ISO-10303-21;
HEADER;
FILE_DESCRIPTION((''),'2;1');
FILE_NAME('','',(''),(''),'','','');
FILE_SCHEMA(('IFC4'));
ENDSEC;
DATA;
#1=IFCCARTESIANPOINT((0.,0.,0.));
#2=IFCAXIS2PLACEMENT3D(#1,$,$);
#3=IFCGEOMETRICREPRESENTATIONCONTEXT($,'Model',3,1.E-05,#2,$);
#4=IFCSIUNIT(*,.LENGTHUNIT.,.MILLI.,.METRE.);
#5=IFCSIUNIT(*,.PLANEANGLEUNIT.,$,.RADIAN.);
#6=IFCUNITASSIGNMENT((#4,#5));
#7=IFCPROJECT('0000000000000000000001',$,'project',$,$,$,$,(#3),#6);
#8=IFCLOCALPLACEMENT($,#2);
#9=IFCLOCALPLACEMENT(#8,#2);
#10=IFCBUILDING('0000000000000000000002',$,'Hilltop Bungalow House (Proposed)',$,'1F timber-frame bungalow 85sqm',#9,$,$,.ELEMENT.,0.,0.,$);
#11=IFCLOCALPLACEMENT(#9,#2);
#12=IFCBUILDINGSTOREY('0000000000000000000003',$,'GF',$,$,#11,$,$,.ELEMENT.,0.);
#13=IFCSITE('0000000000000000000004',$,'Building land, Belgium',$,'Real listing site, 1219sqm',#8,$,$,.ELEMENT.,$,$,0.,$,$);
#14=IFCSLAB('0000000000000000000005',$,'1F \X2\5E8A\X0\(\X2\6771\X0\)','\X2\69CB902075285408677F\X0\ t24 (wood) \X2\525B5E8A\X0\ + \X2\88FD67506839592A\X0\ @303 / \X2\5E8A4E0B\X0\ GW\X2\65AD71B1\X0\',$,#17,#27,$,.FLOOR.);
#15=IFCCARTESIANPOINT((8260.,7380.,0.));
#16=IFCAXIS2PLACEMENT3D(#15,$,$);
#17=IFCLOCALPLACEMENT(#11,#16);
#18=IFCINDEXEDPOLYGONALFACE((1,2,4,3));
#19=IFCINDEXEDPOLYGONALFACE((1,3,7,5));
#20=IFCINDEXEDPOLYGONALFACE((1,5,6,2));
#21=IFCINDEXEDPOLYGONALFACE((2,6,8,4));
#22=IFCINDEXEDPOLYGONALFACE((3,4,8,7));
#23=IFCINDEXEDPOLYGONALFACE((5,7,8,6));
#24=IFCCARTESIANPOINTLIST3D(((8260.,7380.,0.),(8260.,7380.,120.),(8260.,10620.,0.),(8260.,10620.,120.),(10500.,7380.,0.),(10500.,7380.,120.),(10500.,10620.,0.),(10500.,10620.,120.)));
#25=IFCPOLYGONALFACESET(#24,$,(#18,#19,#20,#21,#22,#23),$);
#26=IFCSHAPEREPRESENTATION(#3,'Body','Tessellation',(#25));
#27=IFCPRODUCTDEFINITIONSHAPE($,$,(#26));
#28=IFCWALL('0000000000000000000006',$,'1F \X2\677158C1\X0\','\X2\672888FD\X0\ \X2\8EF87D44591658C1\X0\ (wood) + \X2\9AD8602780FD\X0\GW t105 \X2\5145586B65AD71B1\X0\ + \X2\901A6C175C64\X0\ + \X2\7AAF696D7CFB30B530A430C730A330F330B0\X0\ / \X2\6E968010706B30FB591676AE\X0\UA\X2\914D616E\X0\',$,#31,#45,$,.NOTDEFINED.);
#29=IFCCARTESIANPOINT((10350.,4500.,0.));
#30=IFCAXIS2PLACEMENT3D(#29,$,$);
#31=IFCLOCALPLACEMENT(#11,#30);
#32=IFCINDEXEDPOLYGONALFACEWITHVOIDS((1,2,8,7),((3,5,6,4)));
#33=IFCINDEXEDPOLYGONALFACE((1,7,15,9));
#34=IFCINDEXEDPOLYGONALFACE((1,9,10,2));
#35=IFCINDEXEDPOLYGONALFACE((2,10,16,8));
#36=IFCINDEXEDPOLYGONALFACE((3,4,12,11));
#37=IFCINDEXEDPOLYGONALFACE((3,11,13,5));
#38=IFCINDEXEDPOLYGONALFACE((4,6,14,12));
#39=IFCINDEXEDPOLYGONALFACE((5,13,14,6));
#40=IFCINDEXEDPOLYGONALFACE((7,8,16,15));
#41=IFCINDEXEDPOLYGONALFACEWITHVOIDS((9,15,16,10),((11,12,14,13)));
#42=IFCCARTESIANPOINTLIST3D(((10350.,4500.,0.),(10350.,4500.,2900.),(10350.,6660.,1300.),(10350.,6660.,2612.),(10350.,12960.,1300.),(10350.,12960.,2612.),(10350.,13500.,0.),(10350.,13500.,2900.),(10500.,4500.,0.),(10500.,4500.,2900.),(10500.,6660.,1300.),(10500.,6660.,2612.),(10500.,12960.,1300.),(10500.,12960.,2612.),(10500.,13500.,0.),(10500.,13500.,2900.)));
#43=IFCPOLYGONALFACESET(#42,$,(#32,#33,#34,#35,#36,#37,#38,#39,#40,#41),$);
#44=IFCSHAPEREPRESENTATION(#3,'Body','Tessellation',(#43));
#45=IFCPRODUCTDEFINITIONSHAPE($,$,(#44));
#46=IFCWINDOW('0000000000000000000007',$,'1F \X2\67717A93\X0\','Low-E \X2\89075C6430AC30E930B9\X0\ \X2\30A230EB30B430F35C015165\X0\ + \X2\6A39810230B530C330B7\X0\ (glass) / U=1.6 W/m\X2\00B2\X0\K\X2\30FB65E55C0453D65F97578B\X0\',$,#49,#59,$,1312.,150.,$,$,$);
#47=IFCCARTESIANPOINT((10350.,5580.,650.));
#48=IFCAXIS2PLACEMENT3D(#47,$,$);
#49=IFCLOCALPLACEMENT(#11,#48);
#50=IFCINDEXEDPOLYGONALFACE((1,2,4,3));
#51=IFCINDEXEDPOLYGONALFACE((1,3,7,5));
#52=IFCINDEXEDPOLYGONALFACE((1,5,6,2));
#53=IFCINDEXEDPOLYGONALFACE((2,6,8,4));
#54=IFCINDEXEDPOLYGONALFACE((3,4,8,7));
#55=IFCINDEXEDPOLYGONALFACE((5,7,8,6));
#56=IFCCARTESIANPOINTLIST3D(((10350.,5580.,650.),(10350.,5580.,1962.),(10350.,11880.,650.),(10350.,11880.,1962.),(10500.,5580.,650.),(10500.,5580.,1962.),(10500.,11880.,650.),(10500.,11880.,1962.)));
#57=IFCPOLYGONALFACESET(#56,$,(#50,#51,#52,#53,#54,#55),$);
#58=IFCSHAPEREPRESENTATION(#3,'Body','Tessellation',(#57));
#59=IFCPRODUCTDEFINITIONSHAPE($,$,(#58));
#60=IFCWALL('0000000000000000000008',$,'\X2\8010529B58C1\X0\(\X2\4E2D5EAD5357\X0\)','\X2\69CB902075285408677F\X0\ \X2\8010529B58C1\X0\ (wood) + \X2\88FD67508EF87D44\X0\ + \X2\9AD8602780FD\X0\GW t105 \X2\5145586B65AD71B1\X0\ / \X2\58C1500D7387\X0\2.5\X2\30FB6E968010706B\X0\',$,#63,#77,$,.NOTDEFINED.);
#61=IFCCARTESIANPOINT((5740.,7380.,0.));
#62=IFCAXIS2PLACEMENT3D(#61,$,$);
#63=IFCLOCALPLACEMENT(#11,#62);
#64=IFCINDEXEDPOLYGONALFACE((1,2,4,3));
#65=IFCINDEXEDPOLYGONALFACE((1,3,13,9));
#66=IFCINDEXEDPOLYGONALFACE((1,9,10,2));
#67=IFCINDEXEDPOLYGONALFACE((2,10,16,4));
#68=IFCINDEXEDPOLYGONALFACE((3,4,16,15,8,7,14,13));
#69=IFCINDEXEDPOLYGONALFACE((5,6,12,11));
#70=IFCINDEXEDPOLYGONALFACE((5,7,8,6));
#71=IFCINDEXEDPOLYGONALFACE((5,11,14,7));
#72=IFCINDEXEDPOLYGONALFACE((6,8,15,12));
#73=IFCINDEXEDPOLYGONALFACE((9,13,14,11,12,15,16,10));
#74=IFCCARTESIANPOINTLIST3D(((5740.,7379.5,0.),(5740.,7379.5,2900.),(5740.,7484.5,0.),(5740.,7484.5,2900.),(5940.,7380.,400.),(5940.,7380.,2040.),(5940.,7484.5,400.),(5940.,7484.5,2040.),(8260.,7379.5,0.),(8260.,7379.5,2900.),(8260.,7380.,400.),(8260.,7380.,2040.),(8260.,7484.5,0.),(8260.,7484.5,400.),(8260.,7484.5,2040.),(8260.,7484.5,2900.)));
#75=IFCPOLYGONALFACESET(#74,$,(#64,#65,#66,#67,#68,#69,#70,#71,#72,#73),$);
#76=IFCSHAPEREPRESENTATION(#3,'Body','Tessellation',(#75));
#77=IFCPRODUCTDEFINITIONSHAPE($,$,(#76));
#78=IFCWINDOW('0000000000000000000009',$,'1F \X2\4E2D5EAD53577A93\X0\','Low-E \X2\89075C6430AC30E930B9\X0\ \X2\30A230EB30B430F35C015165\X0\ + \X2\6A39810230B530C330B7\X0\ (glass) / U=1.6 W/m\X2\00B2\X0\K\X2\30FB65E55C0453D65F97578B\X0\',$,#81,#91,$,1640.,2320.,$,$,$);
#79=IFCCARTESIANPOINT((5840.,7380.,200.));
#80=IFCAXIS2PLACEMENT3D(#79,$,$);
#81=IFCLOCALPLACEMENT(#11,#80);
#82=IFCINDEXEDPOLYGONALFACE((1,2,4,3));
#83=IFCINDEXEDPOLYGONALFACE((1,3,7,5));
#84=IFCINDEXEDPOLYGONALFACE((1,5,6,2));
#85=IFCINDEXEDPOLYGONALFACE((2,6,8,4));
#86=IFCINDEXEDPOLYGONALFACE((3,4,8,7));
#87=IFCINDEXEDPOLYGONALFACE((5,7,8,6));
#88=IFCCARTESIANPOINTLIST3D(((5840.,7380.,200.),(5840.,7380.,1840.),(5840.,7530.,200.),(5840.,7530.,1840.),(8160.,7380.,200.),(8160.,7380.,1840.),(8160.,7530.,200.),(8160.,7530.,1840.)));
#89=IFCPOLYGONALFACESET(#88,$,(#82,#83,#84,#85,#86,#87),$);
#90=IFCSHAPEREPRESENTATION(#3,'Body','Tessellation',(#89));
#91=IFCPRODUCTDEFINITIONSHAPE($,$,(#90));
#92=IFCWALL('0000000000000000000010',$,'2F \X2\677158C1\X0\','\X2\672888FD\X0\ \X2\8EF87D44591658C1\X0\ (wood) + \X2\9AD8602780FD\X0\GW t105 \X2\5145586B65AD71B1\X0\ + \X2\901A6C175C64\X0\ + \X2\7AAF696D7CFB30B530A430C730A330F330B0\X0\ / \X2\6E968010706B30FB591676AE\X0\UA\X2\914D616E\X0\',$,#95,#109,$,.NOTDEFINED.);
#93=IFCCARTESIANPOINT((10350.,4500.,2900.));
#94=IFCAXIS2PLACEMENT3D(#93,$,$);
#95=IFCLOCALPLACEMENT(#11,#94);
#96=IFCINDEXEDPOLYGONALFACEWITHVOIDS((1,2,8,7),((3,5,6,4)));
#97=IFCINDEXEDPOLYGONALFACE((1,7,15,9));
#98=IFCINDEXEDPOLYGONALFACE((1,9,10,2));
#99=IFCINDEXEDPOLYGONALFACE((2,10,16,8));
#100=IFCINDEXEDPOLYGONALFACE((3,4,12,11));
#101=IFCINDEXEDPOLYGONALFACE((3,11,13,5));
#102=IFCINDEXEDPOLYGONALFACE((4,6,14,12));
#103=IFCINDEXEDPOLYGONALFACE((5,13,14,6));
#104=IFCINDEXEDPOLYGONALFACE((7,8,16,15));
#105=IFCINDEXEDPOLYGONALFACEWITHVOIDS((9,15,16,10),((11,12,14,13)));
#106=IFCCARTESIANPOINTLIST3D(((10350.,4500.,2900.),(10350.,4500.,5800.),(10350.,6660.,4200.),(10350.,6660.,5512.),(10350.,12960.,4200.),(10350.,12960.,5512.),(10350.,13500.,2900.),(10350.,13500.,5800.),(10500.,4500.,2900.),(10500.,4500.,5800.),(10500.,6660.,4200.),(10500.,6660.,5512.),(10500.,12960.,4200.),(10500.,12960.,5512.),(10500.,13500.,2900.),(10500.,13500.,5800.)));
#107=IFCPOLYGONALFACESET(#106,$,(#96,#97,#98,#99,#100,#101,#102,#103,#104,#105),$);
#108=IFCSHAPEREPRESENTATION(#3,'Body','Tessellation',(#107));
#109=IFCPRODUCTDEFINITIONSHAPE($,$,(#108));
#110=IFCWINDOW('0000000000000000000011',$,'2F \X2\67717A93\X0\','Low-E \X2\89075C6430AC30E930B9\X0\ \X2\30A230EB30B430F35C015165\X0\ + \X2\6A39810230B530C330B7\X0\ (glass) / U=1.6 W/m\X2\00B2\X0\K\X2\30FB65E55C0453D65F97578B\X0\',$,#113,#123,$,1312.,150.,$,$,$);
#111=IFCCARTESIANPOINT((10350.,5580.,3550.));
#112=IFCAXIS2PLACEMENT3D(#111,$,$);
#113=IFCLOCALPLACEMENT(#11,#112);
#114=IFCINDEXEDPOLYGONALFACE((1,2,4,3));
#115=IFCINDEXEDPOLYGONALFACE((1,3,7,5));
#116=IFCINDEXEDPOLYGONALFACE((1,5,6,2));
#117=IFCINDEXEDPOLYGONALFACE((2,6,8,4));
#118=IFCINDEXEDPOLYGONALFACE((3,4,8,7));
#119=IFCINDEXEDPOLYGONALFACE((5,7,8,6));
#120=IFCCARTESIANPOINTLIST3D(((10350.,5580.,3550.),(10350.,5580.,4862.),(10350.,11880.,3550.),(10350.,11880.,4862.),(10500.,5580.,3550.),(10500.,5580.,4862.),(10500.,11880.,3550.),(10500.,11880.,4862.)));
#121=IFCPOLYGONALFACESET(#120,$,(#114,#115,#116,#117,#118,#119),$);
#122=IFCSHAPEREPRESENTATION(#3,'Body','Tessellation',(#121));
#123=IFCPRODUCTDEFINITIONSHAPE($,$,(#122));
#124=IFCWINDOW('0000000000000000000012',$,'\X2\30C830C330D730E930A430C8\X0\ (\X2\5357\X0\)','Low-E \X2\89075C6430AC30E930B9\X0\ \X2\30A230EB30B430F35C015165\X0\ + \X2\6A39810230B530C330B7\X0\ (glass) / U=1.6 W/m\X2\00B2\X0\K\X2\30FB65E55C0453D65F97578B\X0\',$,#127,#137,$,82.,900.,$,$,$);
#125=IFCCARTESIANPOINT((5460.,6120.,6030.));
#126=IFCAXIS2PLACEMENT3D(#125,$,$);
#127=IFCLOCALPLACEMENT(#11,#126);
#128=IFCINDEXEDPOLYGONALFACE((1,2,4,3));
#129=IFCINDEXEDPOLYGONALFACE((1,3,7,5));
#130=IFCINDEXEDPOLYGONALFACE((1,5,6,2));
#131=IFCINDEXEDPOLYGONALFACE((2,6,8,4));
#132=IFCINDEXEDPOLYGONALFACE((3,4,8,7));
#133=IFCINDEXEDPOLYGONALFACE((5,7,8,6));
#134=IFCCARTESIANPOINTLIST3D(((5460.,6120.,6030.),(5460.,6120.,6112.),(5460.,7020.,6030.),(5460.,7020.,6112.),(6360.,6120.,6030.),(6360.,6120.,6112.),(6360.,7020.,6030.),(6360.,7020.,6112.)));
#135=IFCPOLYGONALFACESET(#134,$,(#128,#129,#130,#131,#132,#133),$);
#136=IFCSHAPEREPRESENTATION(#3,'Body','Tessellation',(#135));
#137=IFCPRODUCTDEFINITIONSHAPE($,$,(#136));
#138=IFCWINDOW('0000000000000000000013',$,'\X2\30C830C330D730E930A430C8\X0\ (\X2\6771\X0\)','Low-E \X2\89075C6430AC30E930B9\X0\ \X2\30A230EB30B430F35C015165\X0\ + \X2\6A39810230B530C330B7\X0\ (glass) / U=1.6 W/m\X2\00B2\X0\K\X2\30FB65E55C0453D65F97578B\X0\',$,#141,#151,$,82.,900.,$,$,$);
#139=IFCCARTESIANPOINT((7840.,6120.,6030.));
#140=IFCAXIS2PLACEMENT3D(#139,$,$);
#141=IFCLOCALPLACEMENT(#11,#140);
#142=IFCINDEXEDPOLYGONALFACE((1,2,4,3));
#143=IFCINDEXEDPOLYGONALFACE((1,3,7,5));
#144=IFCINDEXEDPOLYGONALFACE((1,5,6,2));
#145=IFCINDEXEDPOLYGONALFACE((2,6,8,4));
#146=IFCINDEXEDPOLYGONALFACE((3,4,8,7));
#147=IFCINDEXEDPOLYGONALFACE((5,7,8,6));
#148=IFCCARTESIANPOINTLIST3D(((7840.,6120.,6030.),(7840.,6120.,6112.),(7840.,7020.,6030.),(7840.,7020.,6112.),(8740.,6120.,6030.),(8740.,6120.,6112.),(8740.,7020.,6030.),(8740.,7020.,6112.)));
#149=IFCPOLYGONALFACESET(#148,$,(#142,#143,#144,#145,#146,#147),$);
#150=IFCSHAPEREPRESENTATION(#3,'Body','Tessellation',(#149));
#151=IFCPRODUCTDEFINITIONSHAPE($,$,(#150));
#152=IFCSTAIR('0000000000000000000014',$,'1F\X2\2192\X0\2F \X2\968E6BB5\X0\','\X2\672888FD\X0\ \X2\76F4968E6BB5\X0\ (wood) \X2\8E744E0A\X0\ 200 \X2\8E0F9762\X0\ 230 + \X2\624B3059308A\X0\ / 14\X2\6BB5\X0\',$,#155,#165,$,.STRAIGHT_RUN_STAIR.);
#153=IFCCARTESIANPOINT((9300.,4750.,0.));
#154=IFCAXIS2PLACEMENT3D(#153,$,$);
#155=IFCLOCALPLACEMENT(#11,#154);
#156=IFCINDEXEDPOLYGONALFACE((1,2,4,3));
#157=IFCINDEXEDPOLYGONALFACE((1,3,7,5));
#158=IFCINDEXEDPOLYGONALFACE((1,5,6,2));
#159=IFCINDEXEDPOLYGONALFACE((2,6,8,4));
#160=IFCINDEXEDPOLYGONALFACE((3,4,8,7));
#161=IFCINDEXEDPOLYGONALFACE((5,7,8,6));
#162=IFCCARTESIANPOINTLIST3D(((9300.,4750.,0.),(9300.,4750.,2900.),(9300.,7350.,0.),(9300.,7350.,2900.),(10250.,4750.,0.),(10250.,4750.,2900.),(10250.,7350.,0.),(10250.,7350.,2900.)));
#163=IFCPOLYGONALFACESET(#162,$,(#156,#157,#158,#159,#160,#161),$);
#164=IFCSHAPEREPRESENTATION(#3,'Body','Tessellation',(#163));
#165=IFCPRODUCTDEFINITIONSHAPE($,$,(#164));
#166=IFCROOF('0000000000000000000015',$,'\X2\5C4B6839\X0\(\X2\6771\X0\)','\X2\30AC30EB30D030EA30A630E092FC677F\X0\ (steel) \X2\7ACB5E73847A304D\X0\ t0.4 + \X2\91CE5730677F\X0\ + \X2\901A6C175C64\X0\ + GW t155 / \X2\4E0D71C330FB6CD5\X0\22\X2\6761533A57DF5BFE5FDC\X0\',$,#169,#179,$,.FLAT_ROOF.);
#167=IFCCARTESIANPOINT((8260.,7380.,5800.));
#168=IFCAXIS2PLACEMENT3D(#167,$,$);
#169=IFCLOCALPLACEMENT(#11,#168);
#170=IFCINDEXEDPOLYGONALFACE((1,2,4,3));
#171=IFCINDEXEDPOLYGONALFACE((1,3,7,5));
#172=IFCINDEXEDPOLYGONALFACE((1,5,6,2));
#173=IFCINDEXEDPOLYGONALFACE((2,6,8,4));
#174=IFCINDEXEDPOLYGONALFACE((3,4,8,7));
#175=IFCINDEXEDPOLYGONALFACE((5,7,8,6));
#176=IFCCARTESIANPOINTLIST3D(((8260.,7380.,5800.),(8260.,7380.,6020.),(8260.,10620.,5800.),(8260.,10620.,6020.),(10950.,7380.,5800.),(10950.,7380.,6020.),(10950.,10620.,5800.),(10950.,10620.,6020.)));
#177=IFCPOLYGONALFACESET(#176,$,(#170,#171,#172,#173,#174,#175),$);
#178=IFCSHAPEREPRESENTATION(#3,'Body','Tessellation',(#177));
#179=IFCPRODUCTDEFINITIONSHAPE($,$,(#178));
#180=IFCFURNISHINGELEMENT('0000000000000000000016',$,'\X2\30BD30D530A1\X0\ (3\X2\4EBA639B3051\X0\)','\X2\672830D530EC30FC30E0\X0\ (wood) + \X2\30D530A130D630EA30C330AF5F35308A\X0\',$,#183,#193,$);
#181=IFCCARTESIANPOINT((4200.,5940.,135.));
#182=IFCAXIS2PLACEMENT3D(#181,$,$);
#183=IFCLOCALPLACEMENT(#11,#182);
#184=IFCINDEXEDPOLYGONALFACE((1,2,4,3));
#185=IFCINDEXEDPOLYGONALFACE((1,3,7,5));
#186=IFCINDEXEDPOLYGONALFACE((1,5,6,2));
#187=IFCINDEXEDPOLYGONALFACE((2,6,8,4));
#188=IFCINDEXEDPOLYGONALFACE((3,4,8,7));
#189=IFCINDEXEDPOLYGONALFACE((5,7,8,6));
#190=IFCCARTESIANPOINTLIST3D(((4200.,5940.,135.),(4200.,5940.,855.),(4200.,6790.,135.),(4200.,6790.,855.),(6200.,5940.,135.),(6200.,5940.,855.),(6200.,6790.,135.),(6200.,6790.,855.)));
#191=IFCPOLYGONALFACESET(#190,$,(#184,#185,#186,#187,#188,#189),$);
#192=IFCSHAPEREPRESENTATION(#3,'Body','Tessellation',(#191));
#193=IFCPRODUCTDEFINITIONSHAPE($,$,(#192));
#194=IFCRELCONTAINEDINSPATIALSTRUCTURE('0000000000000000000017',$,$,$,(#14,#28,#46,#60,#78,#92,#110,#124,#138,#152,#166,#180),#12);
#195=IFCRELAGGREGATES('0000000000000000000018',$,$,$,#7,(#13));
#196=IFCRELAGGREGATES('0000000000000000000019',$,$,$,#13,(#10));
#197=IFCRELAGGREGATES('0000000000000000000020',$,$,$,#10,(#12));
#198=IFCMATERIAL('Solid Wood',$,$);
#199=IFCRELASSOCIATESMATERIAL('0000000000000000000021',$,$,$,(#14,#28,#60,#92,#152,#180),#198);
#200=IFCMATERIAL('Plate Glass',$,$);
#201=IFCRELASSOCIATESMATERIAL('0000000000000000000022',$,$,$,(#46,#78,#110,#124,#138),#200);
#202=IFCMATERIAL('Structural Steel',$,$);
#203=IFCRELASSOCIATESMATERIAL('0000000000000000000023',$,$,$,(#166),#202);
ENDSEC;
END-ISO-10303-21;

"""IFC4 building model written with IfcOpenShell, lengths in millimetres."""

from ifc_helpers import new_model, si_unit, frame, frame_2d, origin, place, context, project, spatial, rectangle, extrude, material, element, fill, save


model = new_model("IFC4")

# Units and contexts
model_context = context("Model", 3, precision=1e-05, world=origin())
ifc_project = project(units=[si_unit("LENGTHUNIT", "METRE", prefix="MILLI"), si_unit("PLANEANGLEUNIT", "RADIAN")], contexts=[model_context])

# Site, building, storey
site_placement = place(None, origin())
site = spatial("IfcSite", under=ifc_project, at=site_placement, Name="Building land, Belgium", ObjectType="Real listing site, 1219sqm", CompositionType="ELEMENT", RefElevation=0.0)
building_placement = place(site_placement, origin())
building = spatial("IfcBuilding", under=site, at=building_placement, Name="Hilltop Bungalow House (Proposed)", ObjectType="1F timber-frame bungalow 85sqm", CompositionType="ELEMENT", ElevationOfRefHeight=0.0, ElevationOfTerrain=0.0)
storey_placement = place(building_placement, origin())
storey = spatial("IfcBuildingStorey", under=building, at=storey_placement, Name="GF", CompositionType="ELEMENT", Elevation=0.0)

# Slab
ifc_material_1 = material(Name="Solid Wood")
slab_placement = place(storey_placement, frame((8260.0, 7380.0, 0.0)))
element("IfcSlab", 1, at=slab_placement, inside=storey, material=ifc_material_1, Name="1F 床(東)", Description="構造用合板 t24 (wood) 剛床 + 製材根太 @303 / 床下 GW断熱", PredefinedType="FLOOR", context=model_context, shape_type="SweptSolid", body=[
    extrude(rectangle(XDim=2240.0, YDim=3240.0, at=frame_2d((1120.0, 1620.0))), frame((8260.0, 7380.0, 0.0)), (0.0, 0.0, 1.0), 120.0),
])

# Walls, openings, windows
wall_1_placement = place(storey_placement, frame((10350.0, 4500.0, 0.0)))
wall_1 = element("IfcWall", 2, at=wall_1_placement, inside=storey, material=ifc_material_1, Name="1F 東壁", Description="木製 軸組外壁 (wood) + 高性能GW t105 充填断熱 + 通気層 + 窯業系サイディング / 準耐火・外皮UA配慮", PredefinedType="NOTDEFINED", context=model_context, shape_type="SweptSolid", body=[
    extrude(rectangle(XDim=150.0, YDim=9000.0, at=frame_2d((75.0, 4500.0))), frame((10350.0, 4500.0, 0.0)), (0.0, 0.0, 1.0), 2900.0),
])
opening_1_placement = place(storey_placement, frame((10350.0, 5580.0, 650.0)))
opening_1 = element("IfcOpeningElement", 3, at=opening_1_placement, cuts=wall_1, PredefinedType="NOTDEFINED", context=model_context, shape_type="SweptSolid", body=[
    extrude(rectangle(XDim=150.0, YDim=6300.0, at=frame_2d((75.0, 3150.0))), frame((10350.0, 5580.0, 650.0)), (0.0, 0.0, 1.0), 1312.0),
])
ifc_material_2 = material(Name="Plate Glass")
window_1_placement = place(storey_placement, frame((10350.0, 5580.0, 650.0)))
window_1 = element("IfcWindow", 4, at=window_1_placement, inside=storey, material=ifc_material_2, Name="1F 東窓", Description="Low-E 複層ガラス アルゴン封入 + 樹脂サッシ (glass) / U=1.6 W/m²K・日射取得型", OverallHeight=1312.0, OverallWidth=150.0, context=model_context, shape_type="SweptSolid", body=[
    extrude(rectangle(XDim=150.0, YDim=6300.0, at=frame_2d((75.0, 3150.0))), frame((10350.0, 5580.0, 650.0)), (0.0, 0.0, 1.0), 1312.0),
])
fill(opening_1, window_1)
wall_2_placement = place(storey_placement, frame((5740.0, 7380.0, 0.0)))
wall_2 = element("IfcWall", 5, at=wall_2_placement, inside=storey, material=ifc_material_1, Name="耐力壁(中庭南)", Description="構造用合板 耐力壁 (wood) + 製材軸組 + 高性能GW t105 充填断熱 / 壁倍率2.5・準耐火", PredefinedType="NOTDEFINED", context=model_context, shape_type="SweptSolid", body=[
    extrude(rectangle(XDim=2520.0, YDim=105.0, at=frame_2d((1260.0, 52.0))), frame((5740.0, 7380.0, 0.0)), (0.0, 0.0, 1.0), 2900.0),
])
opening_2_placement = place(storey_placement, frame((5840.0, 7380.0, 200.0)))
opening_2 = element("IfcOpeningElement", 6, at=opening_2_placement, cuts=wall_2, PredefinedType="NOTDEFINED", context=model_context, shape_type="SweptSolid", body=[
    extrude(rectangle(XDim=2320.0, YDim=150.0, at=frame_2d((1160.0, 75.0))), frame((5840.0, 7380.0, 200.0)), (0.0, 0.0, 1.0), 1640.0),
])
window_2_placement = place(storey_placement, frame((5840.0, 7380.0, 200.0)))
window_2 = element("IfcWindow", 7, at=window_2_placement, inside=storey, material=ifc_material_2, Name="1F 中庭南窓", Description="Low-E 複層ガラス アルゴン封入 + 樹脂サッシ (glass) / U=1.6 W/m²K・日射取得型", OverallHeight=1640.0, OverallWidth=2320.0, context=model_context, shape_type="SweptSolid", body=[
    extrude(rectangle(XDim=2320.0, YDim=150.0, at=frame_2d((1160.0, 75.0))), frame((5840.0, 7380.0, 200.0)), (0.0, 0.0, 1.0), 1640.0),
])
fill(opening_2, window_2)

# Wall, opening, window
wall_3_placement = place(storey_placement, frame((10350.0, 4500.0, 2900.0)))
wall_3 = element("IfcWall", 8, at=wall_3_placement, inside=storey, material=ifc_material_1, Name="2F 東壁", Description="木製 軸組外壁 (wood) + 高性能GW t105 充填断熱 + 通気層 + 窯業系サイディング / 準耐火・外皮UA配慮", PredefinedType="NOTDEFINED", context=model_context, shape_type="SweptSolid", body=[
    extrude(rectangle(XDim=150.0, YDim=9000.0, at=frame_2d((75.0, 4500.0))), frame((10350.0, 4500.0, 2900.0)), (0.0, 0.0, 1.0), 2900.0),
])
opening_3_placement = place(storey_placement, frame((10350.0, 5580.0, 3550.0)))
opening_3 = element("IfcOpeningElement", 9, at=opening_3_placement, cuts=wall_3, PredefinedType="NOTDEFINED", context=model_context, shape_type="SweptSolid", body=[
    extrude(rectangle(XDim=150.0, YDim=6300.0, at=frame_2d((75.0, 3150.0))), frame((10350.0, 5580.0, 3550.0)), (0.0, 0.0, 1.0), 1312.0),
])
window_3_placement = place(storey_placement, frame((10350.0, 5580.0, 3550.0)))
window_3 = element("IfcWindow", 10, at=window_3_placement, inside=storey, material=ifc_material_2, Name="2F 東窓", Description="Low-E 複層ガラス アルゴン封入 + 樹脂サッシ (glass) / U=1.6 W/m²K・日射取得型", OverallHeight=1312.0, OverallWidth=150.0, context=model_context, shape_type="SweptSolid", body=[
    extrude(rectangle(XDim=150.0, YDim=6300.0, at=frame_2d((75.0, 3150.0))), frame((10350.0, 5580.0, 3550.0)), (0.0, 0.0, 1.0), 1312.0),
])
fill(opening_3, window_3)

# Windows
window_4_placement = place(storey_placement, frame((5460.0, 6120.0, 6030.0)))
element("IfcWindow", 11, at=window_4_placement, inside=storey, material=ifc_material_2, Name="トップライト (南)", Description="Low-E 複層ガラス アルゴン封入 + 樹脂サッシ (glass) / U=1.6 W/m²K・日射取得型", OverallHeight=82.0, OverallWidth=900.0, context=model_context, shape_type="SweptSolid", body=[
    extrude(rectangle(XDim=900.0, YDim=900.0, at=frame_2d((450.0, 450.0))), frame((5460.0, 6120.0, 6030.0)), (0.0, 0.0, 1.0), 82.0),
])
window_5_placement = place(storey_placement, frame((7840.0, 6120.0, 6030.0)))
element("IfcWindow", 12, at=window_5_placement, inside=storey, material=ifc_material_2, Name="トップライト (東)", Description="Low-E 複層ガラス アルゴン封入 + 樹脂サッシ (glass) / U=1.6 W/m²K・日射取得型", OverallHeight=82.0, OverallWidth=900.0, context=model_context, shape_type="SweptSolid", body=[
    extrude(rectangle(XDim=900.0, YDim=900.0, at=frame_2d((450.0, 450.0))), frame((7840.0, 6120.0, 6030.0)), (0.0, 0.0, 1.0), 82.0),
])

# Stair
stair_placement = place(storey_placement, frame((9300.0, 4750.0, 0.0)))
element("IfcStair", 13, at=stair_placement, inside=storey, material=ifc_material_1, Name="1F→2F 階段", Description="木製 直階段 (wood) 蹴上 200 踏面 230 + 手すり / 14段", PredefinedType="STRAIGHT_RUN_STAIR", context=model_context, shape_type="SweptSolid", body=[
    extrude(rectangle(XDim=950.0, YDim=2600.0, at=frame_2d((475.0, 1300.0))), frame((9300.0, 4750.0, 0.0)), (0.0, 0.0, 1.0), 2900.0),
])

# Roof
ifc_material_3 = material(Name="Structural Steel")
roof_placement = place(storey_placement, frame((8260.0, 7380.0, 5800.0)))
element("IfcRoof", 14, at=roof_placement, inside=storey, material=ifc_material_3, Name="屋根(東)", Description="ガルバリウム鋼板 (steel) 立平葺き t0.4 + 野地板 + 通気層 + GW t155 / 不燃・法22条区域対応", PredefinedType="FLAT_ROOF", context=model_context, shape_type="SweptSolid", body=[
    extrude(rectangle(XDim=2690.0, YDim=3240.0, at=frame_2d((1345.0, 1620.0))), frame((8260.0, 7380.0, 5800.0)), (0.0, 0.0, 1.0), 220.0),
])

# Furnishing element
furnishing_1_placement = place(storey_placement, frame((4200.0, 5940.0, 135.0)))
element("IfcFurnishingElement", 15, at=furnishing_1_placement, inside=storey, material=ifc_material_1, Name="ソファ (3人掛け)", Description="木フレーム (wood) + ファブリック張り", context=model_context, shape_type="SweptSolid", body=[
    extrude(rectangle(XDim=2000.0, YDim=850.0, at=frame_2d((1000.0, 425.0))), frame((4200.0, 5940.0, 135.0)), (0.0, 0.0, 1.0), 720.0),
])

save(model, "model.ifc")
